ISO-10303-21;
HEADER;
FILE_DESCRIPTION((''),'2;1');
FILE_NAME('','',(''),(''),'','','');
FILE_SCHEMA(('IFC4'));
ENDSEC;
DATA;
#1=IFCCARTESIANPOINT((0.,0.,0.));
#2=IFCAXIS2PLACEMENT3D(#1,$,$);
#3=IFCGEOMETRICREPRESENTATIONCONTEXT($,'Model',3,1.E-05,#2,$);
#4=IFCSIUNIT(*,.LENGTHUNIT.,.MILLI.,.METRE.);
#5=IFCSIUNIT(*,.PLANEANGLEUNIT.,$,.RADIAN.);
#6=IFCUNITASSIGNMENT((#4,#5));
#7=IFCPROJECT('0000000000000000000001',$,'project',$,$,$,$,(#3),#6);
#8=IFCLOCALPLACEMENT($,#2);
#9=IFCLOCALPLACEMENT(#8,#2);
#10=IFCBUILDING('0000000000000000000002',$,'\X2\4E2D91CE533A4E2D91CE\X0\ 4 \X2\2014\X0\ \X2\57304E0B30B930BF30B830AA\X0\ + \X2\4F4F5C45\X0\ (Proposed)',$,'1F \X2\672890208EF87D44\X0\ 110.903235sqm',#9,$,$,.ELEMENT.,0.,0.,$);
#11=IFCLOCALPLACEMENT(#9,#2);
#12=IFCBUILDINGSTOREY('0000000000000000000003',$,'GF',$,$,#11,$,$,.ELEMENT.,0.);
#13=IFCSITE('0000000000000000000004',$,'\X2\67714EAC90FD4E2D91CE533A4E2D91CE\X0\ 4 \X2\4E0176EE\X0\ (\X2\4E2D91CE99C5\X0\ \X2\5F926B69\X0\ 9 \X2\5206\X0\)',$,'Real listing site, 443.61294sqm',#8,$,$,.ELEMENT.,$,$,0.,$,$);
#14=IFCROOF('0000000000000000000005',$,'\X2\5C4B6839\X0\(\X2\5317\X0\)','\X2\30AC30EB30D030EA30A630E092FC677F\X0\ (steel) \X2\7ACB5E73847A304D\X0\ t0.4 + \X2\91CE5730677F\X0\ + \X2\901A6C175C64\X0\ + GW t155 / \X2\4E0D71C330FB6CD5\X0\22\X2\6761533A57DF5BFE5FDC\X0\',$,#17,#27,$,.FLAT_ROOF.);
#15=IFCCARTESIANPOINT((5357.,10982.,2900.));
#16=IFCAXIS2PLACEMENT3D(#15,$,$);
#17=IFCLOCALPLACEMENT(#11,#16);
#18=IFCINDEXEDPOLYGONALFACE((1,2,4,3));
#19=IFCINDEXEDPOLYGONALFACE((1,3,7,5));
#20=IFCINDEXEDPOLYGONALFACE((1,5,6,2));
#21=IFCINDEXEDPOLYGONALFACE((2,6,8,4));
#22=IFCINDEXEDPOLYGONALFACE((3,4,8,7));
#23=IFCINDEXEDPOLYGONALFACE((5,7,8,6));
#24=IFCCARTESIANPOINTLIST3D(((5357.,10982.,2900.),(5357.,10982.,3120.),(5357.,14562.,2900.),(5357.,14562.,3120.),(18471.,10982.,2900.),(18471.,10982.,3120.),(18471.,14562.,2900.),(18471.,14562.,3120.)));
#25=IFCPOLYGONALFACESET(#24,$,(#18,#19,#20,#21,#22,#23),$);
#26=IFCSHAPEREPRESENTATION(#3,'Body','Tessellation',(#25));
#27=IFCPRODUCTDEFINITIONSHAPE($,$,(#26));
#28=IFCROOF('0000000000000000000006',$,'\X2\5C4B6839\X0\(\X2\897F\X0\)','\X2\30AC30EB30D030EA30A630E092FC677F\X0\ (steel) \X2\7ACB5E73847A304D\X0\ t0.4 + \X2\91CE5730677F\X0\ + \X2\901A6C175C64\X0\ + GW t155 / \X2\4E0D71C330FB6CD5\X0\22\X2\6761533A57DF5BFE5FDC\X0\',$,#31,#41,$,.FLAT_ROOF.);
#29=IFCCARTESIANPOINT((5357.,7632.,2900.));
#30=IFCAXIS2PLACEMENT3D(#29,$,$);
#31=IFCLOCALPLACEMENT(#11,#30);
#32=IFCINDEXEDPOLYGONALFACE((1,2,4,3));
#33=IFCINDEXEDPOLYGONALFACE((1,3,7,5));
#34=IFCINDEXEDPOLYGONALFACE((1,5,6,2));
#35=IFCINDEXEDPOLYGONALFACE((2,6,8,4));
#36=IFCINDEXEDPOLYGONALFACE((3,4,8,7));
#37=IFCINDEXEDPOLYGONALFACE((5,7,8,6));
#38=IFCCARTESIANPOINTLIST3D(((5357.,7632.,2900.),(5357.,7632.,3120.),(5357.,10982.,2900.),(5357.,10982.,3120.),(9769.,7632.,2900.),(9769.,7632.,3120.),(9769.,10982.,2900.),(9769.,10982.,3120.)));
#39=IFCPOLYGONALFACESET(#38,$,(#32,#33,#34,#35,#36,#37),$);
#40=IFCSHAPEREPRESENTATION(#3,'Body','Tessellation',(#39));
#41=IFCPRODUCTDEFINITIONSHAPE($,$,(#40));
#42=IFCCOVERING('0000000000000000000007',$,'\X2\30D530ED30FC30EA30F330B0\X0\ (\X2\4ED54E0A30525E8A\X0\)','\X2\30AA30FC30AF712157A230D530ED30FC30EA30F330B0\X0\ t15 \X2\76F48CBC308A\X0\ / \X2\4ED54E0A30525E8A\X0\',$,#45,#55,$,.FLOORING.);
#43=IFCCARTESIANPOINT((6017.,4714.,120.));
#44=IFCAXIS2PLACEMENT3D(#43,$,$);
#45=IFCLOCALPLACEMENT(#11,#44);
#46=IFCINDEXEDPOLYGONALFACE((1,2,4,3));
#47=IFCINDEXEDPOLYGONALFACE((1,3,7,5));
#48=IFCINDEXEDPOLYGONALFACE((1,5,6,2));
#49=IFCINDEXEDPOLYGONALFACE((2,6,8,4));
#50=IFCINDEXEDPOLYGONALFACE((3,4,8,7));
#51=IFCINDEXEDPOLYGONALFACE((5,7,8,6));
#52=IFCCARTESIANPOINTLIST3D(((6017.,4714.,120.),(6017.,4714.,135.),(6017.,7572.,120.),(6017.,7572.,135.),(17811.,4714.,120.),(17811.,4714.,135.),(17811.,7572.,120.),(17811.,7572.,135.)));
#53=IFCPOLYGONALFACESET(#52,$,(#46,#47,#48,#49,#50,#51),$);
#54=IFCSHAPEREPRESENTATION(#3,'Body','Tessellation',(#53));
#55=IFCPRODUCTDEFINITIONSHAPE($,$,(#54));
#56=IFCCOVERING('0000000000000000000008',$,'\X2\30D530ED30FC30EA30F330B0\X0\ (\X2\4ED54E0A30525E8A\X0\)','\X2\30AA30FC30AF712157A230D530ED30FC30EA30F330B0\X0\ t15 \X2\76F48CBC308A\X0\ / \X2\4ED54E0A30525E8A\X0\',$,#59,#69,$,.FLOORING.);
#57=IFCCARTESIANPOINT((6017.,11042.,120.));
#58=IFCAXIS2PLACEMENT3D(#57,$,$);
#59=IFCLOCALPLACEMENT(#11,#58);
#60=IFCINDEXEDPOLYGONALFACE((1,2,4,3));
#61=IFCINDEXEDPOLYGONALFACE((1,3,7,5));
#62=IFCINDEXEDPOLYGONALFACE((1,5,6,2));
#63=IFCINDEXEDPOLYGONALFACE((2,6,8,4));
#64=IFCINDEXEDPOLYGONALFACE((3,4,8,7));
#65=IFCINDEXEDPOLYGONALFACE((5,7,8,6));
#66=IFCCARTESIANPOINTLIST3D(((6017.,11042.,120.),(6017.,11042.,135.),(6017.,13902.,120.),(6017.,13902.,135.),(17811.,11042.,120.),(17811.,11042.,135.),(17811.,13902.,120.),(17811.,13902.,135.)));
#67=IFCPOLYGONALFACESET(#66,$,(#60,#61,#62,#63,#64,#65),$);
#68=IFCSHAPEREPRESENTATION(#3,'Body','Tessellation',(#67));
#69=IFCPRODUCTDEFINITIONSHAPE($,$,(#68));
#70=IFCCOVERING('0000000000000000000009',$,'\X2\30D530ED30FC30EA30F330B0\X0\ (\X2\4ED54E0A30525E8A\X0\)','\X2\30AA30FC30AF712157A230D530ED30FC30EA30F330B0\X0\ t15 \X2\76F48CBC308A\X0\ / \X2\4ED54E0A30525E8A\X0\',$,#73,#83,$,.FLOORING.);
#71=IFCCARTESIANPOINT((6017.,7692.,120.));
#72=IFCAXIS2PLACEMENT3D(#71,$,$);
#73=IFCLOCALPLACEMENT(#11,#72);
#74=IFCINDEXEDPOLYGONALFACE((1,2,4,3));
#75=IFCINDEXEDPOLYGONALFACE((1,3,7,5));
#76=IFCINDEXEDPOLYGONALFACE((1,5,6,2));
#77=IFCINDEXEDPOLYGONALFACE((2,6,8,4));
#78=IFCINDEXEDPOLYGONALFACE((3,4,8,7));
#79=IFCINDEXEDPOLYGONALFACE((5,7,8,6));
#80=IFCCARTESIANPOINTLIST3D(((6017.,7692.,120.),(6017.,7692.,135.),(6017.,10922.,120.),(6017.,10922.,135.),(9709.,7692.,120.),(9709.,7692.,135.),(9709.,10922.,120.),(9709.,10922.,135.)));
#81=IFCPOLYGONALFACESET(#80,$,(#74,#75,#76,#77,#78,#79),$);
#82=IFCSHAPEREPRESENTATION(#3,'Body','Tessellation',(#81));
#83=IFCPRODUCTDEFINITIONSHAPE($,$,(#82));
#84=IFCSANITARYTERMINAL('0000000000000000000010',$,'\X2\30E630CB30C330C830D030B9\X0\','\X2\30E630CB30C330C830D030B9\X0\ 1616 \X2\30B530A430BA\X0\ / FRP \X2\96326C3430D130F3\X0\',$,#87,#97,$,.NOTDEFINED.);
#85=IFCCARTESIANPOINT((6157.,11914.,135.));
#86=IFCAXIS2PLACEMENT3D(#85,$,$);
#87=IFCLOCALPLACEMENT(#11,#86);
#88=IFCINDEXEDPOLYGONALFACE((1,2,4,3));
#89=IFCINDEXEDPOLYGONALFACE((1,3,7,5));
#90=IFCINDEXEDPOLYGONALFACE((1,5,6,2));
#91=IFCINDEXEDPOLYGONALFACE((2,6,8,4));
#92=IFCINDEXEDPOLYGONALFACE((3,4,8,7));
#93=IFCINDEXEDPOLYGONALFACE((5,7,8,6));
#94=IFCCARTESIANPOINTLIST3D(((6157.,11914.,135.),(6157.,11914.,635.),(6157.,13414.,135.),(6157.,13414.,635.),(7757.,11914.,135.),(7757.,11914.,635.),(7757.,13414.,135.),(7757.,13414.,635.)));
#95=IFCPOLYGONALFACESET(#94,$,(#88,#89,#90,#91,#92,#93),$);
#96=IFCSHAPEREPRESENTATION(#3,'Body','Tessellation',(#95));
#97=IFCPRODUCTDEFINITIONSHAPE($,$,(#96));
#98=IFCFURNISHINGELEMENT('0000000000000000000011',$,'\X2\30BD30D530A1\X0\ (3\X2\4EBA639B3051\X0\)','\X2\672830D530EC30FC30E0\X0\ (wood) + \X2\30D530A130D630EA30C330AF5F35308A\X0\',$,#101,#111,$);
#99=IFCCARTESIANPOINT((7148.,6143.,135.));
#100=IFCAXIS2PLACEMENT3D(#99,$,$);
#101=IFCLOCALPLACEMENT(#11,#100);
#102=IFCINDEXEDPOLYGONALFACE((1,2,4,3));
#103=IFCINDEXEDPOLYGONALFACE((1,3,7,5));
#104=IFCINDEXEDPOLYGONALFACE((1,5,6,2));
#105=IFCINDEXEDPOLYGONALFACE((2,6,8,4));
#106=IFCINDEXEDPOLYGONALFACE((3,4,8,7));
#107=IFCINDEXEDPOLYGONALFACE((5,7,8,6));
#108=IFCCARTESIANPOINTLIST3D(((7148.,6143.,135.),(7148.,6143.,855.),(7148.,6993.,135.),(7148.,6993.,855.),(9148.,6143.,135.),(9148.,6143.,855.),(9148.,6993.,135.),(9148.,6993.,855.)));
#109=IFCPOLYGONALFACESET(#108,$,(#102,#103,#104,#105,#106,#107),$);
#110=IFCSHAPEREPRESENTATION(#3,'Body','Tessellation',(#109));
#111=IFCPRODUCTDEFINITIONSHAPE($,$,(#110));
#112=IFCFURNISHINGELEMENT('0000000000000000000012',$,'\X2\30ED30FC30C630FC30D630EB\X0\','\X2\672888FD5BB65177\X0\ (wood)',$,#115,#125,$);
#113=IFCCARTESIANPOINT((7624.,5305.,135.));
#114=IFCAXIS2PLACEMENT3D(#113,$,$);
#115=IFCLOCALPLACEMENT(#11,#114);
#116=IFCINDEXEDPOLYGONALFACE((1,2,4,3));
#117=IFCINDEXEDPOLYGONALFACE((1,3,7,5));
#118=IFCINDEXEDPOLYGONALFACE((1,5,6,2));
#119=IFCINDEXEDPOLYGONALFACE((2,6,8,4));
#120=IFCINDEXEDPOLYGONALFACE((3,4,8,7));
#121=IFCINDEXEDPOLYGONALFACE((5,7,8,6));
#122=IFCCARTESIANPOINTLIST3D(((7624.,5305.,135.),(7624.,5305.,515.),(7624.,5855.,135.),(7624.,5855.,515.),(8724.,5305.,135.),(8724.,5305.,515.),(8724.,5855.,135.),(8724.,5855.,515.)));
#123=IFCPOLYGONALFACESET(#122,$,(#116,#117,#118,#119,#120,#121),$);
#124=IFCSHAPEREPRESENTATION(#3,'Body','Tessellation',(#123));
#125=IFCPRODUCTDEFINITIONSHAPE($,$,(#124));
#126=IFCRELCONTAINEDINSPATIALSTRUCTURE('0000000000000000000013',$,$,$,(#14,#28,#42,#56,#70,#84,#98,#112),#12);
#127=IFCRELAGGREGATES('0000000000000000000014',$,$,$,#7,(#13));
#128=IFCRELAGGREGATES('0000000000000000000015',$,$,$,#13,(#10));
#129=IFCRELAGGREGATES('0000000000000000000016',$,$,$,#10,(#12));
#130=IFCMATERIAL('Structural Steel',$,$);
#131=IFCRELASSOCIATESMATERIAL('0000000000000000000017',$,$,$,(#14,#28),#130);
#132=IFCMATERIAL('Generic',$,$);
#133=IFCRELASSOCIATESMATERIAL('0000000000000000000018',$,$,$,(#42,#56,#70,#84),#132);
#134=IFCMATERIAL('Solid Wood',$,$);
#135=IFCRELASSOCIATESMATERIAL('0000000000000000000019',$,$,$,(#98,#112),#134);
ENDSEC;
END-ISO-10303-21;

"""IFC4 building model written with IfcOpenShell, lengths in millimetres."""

from ifc_helpers import new_model, si_unit, frame, frame_2d, origin, place, context, project, spatial, rectangle, extrude, material, element, save


model = new_model("IFC4")

# Units and contexts
model_context = context("Model", 3, precision=1e-05, world=origin())
ifc_project = project(units=[si_unit("LENGTHUNIT", "METRE", prefix="MILLI"), si_unit("PLANEANGLEUNIT", "RADIAN")], contexts=[model_context])

# Site, building, storey
site_placement = place(None, origin())
site = spatial("IfcSite", under=ifc_project, at=site_placement, Name="東京都中野区中野 4 丁目 (中野駅 徒歩 9 分)", ObjectType="Real listing site, 443.61294sqm", CompositionType="ELEMENT", RefElevation=0.0)
building_placement = place(site_placement, origin())
building = spatial("IfcBuilding", under=site, at=building_placement, Name="中野区中野 4 — 地下スタジオ + 住居 (Proposed)", ObjectType="1F 木造軸組 110.903235sqm", CompositionType="ELEMENT", ElevationOfRefHeight=0.0, ElevationOfTerrain=0.0)
storey_placement = place(building_placement, origin())
storey = spatial("IfcBuildingStorey", under=building, at=storey_placement, Name="GF", CompositionType="ELEMENT", Elevation=0.0)

# Shared definitions
ifc_material_1 = material(Name="Solid Wood")

# Roofs
ifc_material_2 = material(Name="Structural Steel")
roof_1_placement = place(storey_placement, frame((5357.0, 10982.0, 2900.0)))
element("IfcRoof", 1, at=roof_1_placement, inside=storey, material=ifc_material_2, Name="屋根(北)", Description="ガルバリウム鋼板 (steel) 立平葺き t0.4 + 野地板 + 通気層 + GW t155 / 不燃・法22条区域対応", PredefinedType="FLAT_ROOF", context=model_context, shape_type="SweptSolid", body=[
    extrude(rectangle(XDim=13114.0, YDim=3580.0, at=frame_2d((6557.0, 1790.0))), frame((5357.0, 10982.0, 2900.0)), (0.0, 0.0, 1.0), 220.0),
])
roof_2_placement = place(storey_placement, frame((5357.0, 7632.0, 2900.0)))
element("IfcRoof", 2, at=roof_2_placement, inside=storey, material=ifc_material_2, Name="屋根(西)", Description="ガルバリウム鋼板 (steel) 立平葺き t0.4 + 野地板 + 通気層 + GW t155 / 不燃・法22条区域対応", PredefinedType="FLAT_ROOF", context=model_context, shape_type="SweptSolid", body=[
    extrude(rectangle(XDim=4412.0, YDim=3350.0, at=frame_2d((2206.0, 1675.0))), frame((5357.0, 7632.0, 2900.0)), (0.0, 0.0, 1.0), 220.0),
])

# Coverings
ifc_material_3 = material(Name="Generic")
covering_1_placement = place(storey_placement, frame((6017.0, 4714.0, 120.0)))
element("IfcCovering", 3, at=covering_1_placement, inside=storey, material=ifc_material_3, Name="フローリング (仕上げ床)", Description="オーク無垢フローリング t15 直貼り / 仕上げ床", PredefinedType="FLOORING", context=model_context, shape_type="SweptSolid", body=[
    extrude(rectangle(XDim=11794.0, YDim=2858.0, at=frame_2d((5897.0, 1429.0))), frame((6017.0, 4714.0, 120.0)), (0.0, 0.0, 1.0), 15.0),
])
covering_2_placement = place(storey_placement, frame((6017.0, 11042.0, 120.0)))
element("IfcCovering", 4, at=covering_2_placement, inside=storey, material=ifc_material_3, Name="フローリング (仕上げ床)", Description="オーク無垢フローリング t15 直貼り / 仕上げ床", PredefinedType="FLOORING", context=model_context, shape_type="SweptSolid", body=[
    extrude(rectangle(XDim=11794.0, YDim=2860.0, at=frame_2d((5897.0, 1430.0))), frame((6017.0, 11042.0, 120.0)), (0.0, 0.0, 1.0), 15.0),
])
covering_3_placement = place(storey_placement, frame((6017.0, 7692.0, 120.0)))
element("IfcCovering", 5, at=covering_3_placement, inside=storey, material=ifc_material_3, Name="フローリング (仕上げ床)", Description="オーク無垢フローリング t15 直貼り / 仕上げ床", PredefinedType="FLOORING", context=model_context, shape_type="SweptSolid", body=[
    extrude(rectangle(XDim=3692.0, YDim=3230.0, at=frame_2d((1846.0, 1615.0))), frame((6017.0, 7692.0, 120.0)), (0.0, 0.0, 1.0), 15.0),
])

# Sanitary terminal
sanitary_terminal_placement = place(storey_placement, frame((6157.0, 11914.0, 135.0)))
element("IfcSanitaryTerminal", 6, at=sanitary_terminal_placement, inside=storey, material=ifc_material_3, Name="ユニットバス", Description="ユニットバス 1616 サイズ / FRP 防水パン", PredefinedType="NOTDEFINED", context=model_context, shape_type="SweptSolid", body=[
    extrude(rectangle(XDim=1600.0, YDim=1500.0, at=frame_2d((800.0, 750.0))), frame((6157.0, 11914.0, 135.0)), (0.0, 0.0, 1.0), 500.0),
])

# Furnishing elements
furnishing_1_placement = place(storey_placement, frame((7148.0, 6143.0, 135.0)))
element("IfcFurnishingElement", 7, at=furnishing_1_placement, inside=storey, material=ifc_material_1, Name="ソファ (3人掛け)", Description="木フレーム (wood) + ファブリック張り", context=model_context, shape_type="SweptSolid", body=[
    extrude(rectangle(XDim=2000.0, YDim=850.0, at=frame_2d((1000.0, 425.0))), frame((7148.0, 6143.0, 135.0)), (0.0, 0.0, 1.0), 720.0),
])
furnishing_2_placement = place(storey_placement, frame((7624.0, 5305.0, 135.0)))
element("IfcFurnishingElement", 8, at=furnishing_2_placement, inside=storey, material=ifc_material_1, Name="ローテーブル", Description="木製家具 (wood)", context=model_context, shape_type="SweptSolid", body=[
    extrude(rectangle(XDim=1100.0, YDim=550.0, at=frame_2d((550.0, 275.0))), frame((7624.0, 5305.0, 135.0)), (0.0, 0.0, 1.0), 380.0),
])

save(model, "model.ifc")
